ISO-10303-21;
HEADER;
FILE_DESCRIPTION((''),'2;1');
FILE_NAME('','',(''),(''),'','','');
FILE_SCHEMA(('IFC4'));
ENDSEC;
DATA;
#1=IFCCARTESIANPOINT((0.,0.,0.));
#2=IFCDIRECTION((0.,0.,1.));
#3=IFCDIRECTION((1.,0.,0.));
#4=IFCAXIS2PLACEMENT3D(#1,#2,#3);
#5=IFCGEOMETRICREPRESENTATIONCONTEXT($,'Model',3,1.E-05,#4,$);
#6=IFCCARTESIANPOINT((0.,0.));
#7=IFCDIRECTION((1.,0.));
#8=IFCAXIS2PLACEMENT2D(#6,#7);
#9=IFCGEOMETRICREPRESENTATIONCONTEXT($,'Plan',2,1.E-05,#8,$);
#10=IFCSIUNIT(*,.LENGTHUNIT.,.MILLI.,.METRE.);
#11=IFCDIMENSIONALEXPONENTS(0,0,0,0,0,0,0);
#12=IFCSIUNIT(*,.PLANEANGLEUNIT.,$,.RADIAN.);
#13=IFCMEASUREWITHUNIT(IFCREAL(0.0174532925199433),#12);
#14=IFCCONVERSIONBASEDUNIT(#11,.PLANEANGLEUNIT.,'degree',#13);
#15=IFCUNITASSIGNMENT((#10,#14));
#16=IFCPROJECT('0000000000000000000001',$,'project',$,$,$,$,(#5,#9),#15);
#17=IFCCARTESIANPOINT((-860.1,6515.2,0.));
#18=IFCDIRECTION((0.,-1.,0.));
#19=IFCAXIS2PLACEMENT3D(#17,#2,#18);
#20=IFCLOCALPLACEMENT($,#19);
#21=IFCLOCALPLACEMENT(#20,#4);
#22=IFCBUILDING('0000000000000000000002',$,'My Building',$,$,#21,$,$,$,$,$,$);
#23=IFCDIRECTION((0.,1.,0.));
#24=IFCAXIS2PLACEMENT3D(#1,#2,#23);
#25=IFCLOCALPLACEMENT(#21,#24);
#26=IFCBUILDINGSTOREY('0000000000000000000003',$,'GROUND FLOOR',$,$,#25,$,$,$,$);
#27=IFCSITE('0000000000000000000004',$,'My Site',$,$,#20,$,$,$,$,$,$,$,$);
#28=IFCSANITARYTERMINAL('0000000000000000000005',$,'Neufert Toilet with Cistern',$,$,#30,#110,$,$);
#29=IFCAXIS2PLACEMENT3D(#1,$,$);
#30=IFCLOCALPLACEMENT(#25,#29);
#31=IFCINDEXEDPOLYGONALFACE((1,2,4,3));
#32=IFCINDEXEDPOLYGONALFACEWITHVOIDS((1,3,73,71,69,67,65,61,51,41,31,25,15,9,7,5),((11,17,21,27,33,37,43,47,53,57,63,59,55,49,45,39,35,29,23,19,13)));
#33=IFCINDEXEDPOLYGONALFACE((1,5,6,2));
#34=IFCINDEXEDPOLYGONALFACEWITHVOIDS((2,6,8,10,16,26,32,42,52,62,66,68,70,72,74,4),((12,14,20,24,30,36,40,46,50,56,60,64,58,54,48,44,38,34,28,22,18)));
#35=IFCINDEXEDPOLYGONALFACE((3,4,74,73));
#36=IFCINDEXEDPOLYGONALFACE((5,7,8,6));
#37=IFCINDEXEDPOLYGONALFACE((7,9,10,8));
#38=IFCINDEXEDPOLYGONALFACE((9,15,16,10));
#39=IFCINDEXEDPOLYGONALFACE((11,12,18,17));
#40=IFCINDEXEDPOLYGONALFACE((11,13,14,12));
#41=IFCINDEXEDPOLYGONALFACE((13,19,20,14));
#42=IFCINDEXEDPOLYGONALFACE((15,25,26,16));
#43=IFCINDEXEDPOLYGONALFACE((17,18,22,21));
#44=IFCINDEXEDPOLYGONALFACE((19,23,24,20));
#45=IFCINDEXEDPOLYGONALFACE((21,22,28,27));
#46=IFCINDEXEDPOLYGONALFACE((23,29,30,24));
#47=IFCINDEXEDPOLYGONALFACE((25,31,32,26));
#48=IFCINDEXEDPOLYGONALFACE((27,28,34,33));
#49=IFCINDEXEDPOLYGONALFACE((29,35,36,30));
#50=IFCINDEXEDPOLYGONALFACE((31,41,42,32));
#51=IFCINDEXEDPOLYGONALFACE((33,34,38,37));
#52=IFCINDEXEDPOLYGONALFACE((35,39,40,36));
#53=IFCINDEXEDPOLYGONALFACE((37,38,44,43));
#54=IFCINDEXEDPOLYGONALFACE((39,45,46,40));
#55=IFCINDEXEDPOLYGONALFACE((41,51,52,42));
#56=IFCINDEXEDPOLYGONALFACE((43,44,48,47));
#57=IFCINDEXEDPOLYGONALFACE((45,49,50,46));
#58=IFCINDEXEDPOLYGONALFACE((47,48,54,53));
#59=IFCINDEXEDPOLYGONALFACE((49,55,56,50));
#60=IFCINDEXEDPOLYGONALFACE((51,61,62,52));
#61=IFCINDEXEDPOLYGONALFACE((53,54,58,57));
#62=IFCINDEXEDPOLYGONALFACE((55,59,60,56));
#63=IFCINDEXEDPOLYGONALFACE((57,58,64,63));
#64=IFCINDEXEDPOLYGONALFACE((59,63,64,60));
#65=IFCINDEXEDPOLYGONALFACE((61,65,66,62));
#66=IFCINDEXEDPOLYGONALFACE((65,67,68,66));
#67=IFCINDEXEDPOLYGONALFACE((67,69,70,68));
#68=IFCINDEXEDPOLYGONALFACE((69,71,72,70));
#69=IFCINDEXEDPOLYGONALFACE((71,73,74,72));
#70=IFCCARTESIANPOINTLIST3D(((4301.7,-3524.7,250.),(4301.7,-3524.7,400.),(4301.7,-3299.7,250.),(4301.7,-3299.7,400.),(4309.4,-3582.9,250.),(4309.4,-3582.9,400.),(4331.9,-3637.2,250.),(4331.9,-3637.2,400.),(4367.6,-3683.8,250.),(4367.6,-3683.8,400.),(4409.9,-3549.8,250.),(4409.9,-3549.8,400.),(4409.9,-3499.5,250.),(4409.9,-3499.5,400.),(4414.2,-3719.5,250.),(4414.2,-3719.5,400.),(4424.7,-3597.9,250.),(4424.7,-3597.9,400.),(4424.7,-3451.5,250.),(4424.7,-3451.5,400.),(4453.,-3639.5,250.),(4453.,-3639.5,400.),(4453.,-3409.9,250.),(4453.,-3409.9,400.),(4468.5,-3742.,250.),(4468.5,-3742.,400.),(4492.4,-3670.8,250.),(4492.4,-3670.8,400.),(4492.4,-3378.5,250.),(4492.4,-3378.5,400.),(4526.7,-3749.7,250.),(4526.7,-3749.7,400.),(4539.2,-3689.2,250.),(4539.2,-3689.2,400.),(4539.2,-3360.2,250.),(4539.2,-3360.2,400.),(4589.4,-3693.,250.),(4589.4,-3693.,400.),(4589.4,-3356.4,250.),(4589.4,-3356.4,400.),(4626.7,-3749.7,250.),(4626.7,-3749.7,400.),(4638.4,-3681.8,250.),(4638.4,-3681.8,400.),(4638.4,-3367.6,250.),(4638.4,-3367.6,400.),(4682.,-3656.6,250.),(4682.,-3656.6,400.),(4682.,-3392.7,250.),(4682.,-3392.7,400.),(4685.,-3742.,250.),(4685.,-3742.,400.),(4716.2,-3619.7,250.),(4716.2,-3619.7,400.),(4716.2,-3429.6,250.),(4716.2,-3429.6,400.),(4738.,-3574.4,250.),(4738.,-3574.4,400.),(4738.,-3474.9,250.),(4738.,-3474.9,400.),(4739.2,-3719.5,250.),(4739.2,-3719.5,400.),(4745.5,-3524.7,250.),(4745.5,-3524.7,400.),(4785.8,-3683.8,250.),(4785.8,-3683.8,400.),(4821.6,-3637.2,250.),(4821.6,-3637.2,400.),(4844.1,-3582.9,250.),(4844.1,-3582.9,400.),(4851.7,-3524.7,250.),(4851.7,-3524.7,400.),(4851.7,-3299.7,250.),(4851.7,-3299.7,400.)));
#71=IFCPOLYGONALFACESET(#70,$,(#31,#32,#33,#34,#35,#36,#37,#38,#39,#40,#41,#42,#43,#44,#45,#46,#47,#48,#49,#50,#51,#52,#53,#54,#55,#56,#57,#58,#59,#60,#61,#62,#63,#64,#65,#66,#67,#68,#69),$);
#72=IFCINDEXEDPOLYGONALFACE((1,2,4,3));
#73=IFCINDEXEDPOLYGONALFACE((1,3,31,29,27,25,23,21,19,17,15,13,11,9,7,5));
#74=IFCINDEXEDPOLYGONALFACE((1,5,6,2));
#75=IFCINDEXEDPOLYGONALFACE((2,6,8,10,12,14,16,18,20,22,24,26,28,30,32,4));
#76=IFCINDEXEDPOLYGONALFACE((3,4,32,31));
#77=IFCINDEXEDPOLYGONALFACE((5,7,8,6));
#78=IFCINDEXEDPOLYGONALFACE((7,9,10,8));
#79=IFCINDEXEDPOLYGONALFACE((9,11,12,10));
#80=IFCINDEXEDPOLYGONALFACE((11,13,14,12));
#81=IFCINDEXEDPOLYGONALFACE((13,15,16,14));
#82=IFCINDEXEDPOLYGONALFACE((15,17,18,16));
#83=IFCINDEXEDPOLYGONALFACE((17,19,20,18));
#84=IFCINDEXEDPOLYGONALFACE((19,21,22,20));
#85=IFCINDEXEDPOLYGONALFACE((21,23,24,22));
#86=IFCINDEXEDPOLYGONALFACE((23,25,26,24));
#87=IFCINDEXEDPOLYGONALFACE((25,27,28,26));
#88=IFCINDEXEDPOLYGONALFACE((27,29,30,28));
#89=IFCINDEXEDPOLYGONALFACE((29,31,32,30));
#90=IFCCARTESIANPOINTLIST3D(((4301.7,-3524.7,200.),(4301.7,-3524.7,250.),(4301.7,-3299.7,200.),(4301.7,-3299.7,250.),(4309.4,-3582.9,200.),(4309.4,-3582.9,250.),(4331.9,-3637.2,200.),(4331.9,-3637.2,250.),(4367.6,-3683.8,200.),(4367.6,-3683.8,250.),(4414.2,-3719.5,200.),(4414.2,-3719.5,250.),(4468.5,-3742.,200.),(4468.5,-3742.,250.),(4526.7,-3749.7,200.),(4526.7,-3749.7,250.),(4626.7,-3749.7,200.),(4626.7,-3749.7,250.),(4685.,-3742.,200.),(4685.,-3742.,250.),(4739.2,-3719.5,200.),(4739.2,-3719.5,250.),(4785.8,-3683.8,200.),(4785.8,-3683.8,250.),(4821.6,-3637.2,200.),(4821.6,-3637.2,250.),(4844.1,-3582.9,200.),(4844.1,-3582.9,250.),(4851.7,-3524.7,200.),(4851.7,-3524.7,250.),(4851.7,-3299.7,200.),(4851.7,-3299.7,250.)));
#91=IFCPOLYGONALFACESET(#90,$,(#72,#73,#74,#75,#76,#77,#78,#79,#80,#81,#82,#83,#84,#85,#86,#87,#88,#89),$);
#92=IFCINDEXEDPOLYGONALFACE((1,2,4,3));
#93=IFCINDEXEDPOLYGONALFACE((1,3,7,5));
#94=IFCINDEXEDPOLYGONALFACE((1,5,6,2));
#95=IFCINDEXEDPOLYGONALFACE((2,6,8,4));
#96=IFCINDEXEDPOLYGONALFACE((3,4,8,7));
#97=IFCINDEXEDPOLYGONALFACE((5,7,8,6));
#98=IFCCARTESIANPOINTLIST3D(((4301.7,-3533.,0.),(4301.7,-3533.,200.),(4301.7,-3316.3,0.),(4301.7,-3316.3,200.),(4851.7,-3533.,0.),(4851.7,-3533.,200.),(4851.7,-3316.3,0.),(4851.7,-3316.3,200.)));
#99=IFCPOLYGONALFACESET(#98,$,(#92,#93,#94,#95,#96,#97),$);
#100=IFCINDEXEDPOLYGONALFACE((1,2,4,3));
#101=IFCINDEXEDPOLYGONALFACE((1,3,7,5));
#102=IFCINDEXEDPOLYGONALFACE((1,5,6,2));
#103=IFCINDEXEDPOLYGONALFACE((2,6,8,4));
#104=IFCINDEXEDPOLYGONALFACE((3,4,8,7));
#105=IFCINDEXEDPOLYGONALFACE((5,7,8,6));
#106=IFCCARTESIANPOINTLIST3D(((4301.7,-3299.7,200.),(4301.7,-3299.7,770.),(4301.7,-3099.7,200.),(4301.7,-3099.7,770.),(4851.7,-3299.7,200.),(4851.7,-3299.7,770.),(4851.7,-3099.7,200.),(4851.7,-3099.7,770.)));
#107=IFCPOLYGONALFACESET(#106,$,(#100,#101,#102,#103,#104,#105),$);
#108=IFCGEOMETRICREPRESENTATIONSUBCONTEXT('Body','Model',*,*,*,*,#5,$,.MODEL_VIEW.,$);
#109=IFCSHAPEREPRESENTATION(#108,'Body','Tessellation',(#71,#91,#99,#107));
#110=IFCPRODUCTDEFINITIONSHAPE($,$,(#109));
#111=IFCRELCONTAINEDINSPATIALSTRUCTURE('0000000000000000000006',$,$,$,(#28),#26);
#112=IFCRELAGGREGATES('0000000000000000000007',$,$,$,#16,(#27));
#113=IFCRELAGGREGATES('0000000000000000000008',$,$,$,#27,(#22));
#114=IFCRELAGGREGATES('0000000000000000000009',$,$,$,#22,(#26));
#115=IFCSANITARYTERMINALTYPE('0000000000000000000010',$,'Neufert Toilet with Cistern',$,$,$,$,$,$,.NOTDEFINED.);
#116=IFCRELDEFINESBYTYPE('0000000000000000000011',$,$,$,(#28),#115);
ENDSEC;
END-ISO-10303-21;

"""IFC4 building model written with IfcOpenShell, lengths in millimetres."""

from ifc_helpers import new_model, entity, si_unit, converted_unit, frame, frame_2d, origin_with_axes, origin_2d_with_axis, place, context, subcontext, project, spatial, line, arc, indexed_curve, circle_curve, outline, extrude, shape, source, transform, mapped, type_object, type_shapes, element, save


model = new_model("IFC4")

# Units and contexts
model_context = context("Model", 3, precision=1e-05, world=origin_with_axes())
plan_context = context("Plan", 2, precision=1e-05, world=origin_2d_with_axis())
body_context_1 = subcontext(model_context, "Body", "Model", "MODEL_VIEW")
body_context_2 = subcontext(plan_context, "Body", "Plan", "PLAN_VIEW")
ifc_project = project(units=[si_unit("LENGTHUNIT", "METRE", prefix="MILLI"), converted_unit("PLANEANGLEUNIT", "degree", entity("IfcReal", 0.0174532925199433), si_unit("PLANEANGLEUNIT", "RADIAN"), dimensions=[0, 0, 0, 0, 0, 0, 0])], contexts=[model_context, plan_context])

# Site, building, storey
site_placement = place(None, frame((-860.1, 6515.2, 0.0), z_axis=(0.0, 0.0, 1.0), x_axis=(0.0, -1.0, 0.0)))
site = spatial("IfcSite", under=ifc_project, at=site_placement, Name="My Site")
building_placement = place(site_placement, frame((0.0, 0.0, 0.0), z_axis=(0.0, 0.0, 1.0), x_axis=(1.0, 0.0, 0.0)))
building = spatial("IfcBuilding", under=site, at=building_placement, Name="My Building")
storey_placement = place(building_placement, frame((0.0, 0.0, 0.0), z_axis=(0.0, 0.0, 1.0), x_axis=(0.0, 1.0, 0.0)))
storey = spatial("IfcBuildingStorey", under=building, at=storey_placement, Name="GROUND FLOOR")

# Sanitary terminal
sanitary_terminal_type_1 = type_object("IfcSanitaryTerminalType", Name="Neufert Toilet with Cistern", PredefinedType="NOTDEFINED")
shared_shape_1 = source(origin_with_axes(), body_context_1, "Body", "SweptSolid", [
    extrude(outline(indexed_curve([(-275.0, -200.0), (275.0, -200.0), (275.0, -425.0), (209.1, -584.1), (50.0, -650.0), (-50.0, -650.0), (-209.1, -584.1), (-275.0, -425.0)], segments=[line(1, 2), line(2, 3), arc(3, 4, 5), line(5, 6), arc(6, 7, 8), line(8, 1)]), holes=[circle_curve(frame_2d((0.0, -425.0)), 168.8)]), frame((0.0, 0.0, 250.0), z_axis=(0.0, 0.0, 1.0), x_axis=(1.0, 0.0, 0.0)), (0.0, 0.0, 1.0), 150.0),
    extrude(outline(indexed_curve([(-275.0, -200.0), (275.0, -200.0), (275.0, -425.0), (209.1, -584.1), (50.0, -650.0), (-50.0, -650.0), (-209.1, -584.1), (-275.0, -425.0)], segments=[line(1, 2), line(2, 3), arc(3, 4, 5), line(5, 6), arc(6, 7, 8), line(8, 1)])), frame((0.0, 0.0, 200.0), z_axis=(0.0, 0.0, 1.0), x_axis=(1.0, 0.0, 0.0)), (0.0, 0.0, 1.0), 50.0),
    extrude(outline(indexed_curve([(-275.0, -216.7), (275.0, -216.7), (275.0, -433.3), (-275.0, -433.3)], segments=[line(1, 2), line(2, 3), line(3, 4), line(4, 1)])), origin_with_axes(), (0.0, 0.0, 1.0), 200.0),
    extrude(outline(indexed_curve([(-275.0, 0.0), (275.0, 0.0), (275.0, -200.0), (-275.0, -200.0)], segments=[line(1, 2), line(2, 3), line(3, 4), line(4, 1)])), frame((0.0, 0.0, 200.0), z_axis=(0.0, 0.0, 1.0), x_axis=(1.0, 0.0, 0.0)), (0.0, 0.0, 1.0), 570.0),
])
shared_shape_2 = source(origin_with_axes(), body_context_2, "Body", "Curve2D", [
    entity("IfcIndexedPolyCurve", entity("IfcCartesianPointList2D", [[-275.0, 0.0], [275.0, 0.0], [275.0, -200.0], [-275.0, -200.0]]), [entity("IfcLineIndex", [1, 2]), entity("IfcLineIndex", [2, 3]), entity("IfcLineIndex", [3, 4]), entity("IfcLineIndex", [4, 1])]),
    entity("IfcIndexedPolyCurve", entity("IfcCartesianPointList2D", [[165.0, -200.0], [192.5, -335.0]]), [entity("IfcLineIndex", [1, 2])]),
    entity("IfcTrimmedCurve", entity("IfcEllipse", entity("IfcAxis2Placement2D", entity("IfcCartesianPoint", [0.0, -335.0]), entity("IfcDirection", [1.0, 0.0])), 192.5, 315.0), [entity("IfcCartesianPoint", [-192.5, -335.0])], [entity("IfcCartesianPoint", [192.5, -335.0])], True, "CARTESIAN"),
    entity("IfcIndexedPolyCurve", entity("IfcCartesianPointList2D", [[-165.0, -200.0], [-192.5, -335.0]]), [entity("IfcLineIndex", [1, 2])]),
    entity("IfcEllipse", entity("IfcAxis2Placement2D", entity("IfcCartesianPoint", [0.0, -452.0]), entity("IfcDirection", [1.0, 0.0])), 131.2, 157.5),
    entity("IfcIndexedPolyCurve", entity("IfcCartesianPointList2D", [[-34.4, -452.0], [-34.4, -429.5], [34.4, -429.5], [34.4, -452.0]]), [entity("IfcLineIndex", [1, 2]), entity("IfcLineIndex", [2, 3]), entity("IfcLineIndex", [3, 4])]),
    entity("IfcTrimmedCurve", entity("IfcEllipse", entity("IfcAxis2Placement2D", entity("IfcCartesianPoint", [0.0, -452.0]), entity("IfcDirection", [1.0, 0.0])), 34.4, 22.5), [entity("IfcCartesianPoint", [-34.4, -452.0])], [entity("IfcCartesianPoint", [34.4, -452.0])], True, "CARTESIAN"),
])
type_shapes(sanitary_terminal_type_1, [shared_shape_1, shared_shape_2])
for number, where, z_axis, x_axis, name in (
    (1, (4576.7, -3099.7, 0.0), (0.0, 0.0, 1.0), (1.0, 0.0, 0.0), "Neufert Toilet with Cistern"),
):
    element("IfcSanitaryTerminal", number, at=place(storey_placement, frame(where, z_axis=z_axis, x_axis=x_axis)), inside=storey, type_object=sanitary_terminal_type_1, Name=name, shapes=[
        shape(body_context_1, "Body", "MappedRepresentation", [mapped(shared_shape_1, transform((0.0, 0.0, 0.0), x_axis=(1.0, 0.0, 0.0), y_axis=(0.0, 1.0, 0.0), z_axis=(0.0, 0.0, 1.0), scale=1.0))]),
        shape(body_context_2, "Body", "MappedRepresentation", [mapped(shared_shape_2, transform((0.0, 0.0, 0.0), x_axis=(1.0, 0.0, 0.0), y_axis=(0.0, 1.0, 0.0), z_axis=(0.0, 0.0, 1.0), scale=1.0))]),
    ])

save(model, "model.ifc")
